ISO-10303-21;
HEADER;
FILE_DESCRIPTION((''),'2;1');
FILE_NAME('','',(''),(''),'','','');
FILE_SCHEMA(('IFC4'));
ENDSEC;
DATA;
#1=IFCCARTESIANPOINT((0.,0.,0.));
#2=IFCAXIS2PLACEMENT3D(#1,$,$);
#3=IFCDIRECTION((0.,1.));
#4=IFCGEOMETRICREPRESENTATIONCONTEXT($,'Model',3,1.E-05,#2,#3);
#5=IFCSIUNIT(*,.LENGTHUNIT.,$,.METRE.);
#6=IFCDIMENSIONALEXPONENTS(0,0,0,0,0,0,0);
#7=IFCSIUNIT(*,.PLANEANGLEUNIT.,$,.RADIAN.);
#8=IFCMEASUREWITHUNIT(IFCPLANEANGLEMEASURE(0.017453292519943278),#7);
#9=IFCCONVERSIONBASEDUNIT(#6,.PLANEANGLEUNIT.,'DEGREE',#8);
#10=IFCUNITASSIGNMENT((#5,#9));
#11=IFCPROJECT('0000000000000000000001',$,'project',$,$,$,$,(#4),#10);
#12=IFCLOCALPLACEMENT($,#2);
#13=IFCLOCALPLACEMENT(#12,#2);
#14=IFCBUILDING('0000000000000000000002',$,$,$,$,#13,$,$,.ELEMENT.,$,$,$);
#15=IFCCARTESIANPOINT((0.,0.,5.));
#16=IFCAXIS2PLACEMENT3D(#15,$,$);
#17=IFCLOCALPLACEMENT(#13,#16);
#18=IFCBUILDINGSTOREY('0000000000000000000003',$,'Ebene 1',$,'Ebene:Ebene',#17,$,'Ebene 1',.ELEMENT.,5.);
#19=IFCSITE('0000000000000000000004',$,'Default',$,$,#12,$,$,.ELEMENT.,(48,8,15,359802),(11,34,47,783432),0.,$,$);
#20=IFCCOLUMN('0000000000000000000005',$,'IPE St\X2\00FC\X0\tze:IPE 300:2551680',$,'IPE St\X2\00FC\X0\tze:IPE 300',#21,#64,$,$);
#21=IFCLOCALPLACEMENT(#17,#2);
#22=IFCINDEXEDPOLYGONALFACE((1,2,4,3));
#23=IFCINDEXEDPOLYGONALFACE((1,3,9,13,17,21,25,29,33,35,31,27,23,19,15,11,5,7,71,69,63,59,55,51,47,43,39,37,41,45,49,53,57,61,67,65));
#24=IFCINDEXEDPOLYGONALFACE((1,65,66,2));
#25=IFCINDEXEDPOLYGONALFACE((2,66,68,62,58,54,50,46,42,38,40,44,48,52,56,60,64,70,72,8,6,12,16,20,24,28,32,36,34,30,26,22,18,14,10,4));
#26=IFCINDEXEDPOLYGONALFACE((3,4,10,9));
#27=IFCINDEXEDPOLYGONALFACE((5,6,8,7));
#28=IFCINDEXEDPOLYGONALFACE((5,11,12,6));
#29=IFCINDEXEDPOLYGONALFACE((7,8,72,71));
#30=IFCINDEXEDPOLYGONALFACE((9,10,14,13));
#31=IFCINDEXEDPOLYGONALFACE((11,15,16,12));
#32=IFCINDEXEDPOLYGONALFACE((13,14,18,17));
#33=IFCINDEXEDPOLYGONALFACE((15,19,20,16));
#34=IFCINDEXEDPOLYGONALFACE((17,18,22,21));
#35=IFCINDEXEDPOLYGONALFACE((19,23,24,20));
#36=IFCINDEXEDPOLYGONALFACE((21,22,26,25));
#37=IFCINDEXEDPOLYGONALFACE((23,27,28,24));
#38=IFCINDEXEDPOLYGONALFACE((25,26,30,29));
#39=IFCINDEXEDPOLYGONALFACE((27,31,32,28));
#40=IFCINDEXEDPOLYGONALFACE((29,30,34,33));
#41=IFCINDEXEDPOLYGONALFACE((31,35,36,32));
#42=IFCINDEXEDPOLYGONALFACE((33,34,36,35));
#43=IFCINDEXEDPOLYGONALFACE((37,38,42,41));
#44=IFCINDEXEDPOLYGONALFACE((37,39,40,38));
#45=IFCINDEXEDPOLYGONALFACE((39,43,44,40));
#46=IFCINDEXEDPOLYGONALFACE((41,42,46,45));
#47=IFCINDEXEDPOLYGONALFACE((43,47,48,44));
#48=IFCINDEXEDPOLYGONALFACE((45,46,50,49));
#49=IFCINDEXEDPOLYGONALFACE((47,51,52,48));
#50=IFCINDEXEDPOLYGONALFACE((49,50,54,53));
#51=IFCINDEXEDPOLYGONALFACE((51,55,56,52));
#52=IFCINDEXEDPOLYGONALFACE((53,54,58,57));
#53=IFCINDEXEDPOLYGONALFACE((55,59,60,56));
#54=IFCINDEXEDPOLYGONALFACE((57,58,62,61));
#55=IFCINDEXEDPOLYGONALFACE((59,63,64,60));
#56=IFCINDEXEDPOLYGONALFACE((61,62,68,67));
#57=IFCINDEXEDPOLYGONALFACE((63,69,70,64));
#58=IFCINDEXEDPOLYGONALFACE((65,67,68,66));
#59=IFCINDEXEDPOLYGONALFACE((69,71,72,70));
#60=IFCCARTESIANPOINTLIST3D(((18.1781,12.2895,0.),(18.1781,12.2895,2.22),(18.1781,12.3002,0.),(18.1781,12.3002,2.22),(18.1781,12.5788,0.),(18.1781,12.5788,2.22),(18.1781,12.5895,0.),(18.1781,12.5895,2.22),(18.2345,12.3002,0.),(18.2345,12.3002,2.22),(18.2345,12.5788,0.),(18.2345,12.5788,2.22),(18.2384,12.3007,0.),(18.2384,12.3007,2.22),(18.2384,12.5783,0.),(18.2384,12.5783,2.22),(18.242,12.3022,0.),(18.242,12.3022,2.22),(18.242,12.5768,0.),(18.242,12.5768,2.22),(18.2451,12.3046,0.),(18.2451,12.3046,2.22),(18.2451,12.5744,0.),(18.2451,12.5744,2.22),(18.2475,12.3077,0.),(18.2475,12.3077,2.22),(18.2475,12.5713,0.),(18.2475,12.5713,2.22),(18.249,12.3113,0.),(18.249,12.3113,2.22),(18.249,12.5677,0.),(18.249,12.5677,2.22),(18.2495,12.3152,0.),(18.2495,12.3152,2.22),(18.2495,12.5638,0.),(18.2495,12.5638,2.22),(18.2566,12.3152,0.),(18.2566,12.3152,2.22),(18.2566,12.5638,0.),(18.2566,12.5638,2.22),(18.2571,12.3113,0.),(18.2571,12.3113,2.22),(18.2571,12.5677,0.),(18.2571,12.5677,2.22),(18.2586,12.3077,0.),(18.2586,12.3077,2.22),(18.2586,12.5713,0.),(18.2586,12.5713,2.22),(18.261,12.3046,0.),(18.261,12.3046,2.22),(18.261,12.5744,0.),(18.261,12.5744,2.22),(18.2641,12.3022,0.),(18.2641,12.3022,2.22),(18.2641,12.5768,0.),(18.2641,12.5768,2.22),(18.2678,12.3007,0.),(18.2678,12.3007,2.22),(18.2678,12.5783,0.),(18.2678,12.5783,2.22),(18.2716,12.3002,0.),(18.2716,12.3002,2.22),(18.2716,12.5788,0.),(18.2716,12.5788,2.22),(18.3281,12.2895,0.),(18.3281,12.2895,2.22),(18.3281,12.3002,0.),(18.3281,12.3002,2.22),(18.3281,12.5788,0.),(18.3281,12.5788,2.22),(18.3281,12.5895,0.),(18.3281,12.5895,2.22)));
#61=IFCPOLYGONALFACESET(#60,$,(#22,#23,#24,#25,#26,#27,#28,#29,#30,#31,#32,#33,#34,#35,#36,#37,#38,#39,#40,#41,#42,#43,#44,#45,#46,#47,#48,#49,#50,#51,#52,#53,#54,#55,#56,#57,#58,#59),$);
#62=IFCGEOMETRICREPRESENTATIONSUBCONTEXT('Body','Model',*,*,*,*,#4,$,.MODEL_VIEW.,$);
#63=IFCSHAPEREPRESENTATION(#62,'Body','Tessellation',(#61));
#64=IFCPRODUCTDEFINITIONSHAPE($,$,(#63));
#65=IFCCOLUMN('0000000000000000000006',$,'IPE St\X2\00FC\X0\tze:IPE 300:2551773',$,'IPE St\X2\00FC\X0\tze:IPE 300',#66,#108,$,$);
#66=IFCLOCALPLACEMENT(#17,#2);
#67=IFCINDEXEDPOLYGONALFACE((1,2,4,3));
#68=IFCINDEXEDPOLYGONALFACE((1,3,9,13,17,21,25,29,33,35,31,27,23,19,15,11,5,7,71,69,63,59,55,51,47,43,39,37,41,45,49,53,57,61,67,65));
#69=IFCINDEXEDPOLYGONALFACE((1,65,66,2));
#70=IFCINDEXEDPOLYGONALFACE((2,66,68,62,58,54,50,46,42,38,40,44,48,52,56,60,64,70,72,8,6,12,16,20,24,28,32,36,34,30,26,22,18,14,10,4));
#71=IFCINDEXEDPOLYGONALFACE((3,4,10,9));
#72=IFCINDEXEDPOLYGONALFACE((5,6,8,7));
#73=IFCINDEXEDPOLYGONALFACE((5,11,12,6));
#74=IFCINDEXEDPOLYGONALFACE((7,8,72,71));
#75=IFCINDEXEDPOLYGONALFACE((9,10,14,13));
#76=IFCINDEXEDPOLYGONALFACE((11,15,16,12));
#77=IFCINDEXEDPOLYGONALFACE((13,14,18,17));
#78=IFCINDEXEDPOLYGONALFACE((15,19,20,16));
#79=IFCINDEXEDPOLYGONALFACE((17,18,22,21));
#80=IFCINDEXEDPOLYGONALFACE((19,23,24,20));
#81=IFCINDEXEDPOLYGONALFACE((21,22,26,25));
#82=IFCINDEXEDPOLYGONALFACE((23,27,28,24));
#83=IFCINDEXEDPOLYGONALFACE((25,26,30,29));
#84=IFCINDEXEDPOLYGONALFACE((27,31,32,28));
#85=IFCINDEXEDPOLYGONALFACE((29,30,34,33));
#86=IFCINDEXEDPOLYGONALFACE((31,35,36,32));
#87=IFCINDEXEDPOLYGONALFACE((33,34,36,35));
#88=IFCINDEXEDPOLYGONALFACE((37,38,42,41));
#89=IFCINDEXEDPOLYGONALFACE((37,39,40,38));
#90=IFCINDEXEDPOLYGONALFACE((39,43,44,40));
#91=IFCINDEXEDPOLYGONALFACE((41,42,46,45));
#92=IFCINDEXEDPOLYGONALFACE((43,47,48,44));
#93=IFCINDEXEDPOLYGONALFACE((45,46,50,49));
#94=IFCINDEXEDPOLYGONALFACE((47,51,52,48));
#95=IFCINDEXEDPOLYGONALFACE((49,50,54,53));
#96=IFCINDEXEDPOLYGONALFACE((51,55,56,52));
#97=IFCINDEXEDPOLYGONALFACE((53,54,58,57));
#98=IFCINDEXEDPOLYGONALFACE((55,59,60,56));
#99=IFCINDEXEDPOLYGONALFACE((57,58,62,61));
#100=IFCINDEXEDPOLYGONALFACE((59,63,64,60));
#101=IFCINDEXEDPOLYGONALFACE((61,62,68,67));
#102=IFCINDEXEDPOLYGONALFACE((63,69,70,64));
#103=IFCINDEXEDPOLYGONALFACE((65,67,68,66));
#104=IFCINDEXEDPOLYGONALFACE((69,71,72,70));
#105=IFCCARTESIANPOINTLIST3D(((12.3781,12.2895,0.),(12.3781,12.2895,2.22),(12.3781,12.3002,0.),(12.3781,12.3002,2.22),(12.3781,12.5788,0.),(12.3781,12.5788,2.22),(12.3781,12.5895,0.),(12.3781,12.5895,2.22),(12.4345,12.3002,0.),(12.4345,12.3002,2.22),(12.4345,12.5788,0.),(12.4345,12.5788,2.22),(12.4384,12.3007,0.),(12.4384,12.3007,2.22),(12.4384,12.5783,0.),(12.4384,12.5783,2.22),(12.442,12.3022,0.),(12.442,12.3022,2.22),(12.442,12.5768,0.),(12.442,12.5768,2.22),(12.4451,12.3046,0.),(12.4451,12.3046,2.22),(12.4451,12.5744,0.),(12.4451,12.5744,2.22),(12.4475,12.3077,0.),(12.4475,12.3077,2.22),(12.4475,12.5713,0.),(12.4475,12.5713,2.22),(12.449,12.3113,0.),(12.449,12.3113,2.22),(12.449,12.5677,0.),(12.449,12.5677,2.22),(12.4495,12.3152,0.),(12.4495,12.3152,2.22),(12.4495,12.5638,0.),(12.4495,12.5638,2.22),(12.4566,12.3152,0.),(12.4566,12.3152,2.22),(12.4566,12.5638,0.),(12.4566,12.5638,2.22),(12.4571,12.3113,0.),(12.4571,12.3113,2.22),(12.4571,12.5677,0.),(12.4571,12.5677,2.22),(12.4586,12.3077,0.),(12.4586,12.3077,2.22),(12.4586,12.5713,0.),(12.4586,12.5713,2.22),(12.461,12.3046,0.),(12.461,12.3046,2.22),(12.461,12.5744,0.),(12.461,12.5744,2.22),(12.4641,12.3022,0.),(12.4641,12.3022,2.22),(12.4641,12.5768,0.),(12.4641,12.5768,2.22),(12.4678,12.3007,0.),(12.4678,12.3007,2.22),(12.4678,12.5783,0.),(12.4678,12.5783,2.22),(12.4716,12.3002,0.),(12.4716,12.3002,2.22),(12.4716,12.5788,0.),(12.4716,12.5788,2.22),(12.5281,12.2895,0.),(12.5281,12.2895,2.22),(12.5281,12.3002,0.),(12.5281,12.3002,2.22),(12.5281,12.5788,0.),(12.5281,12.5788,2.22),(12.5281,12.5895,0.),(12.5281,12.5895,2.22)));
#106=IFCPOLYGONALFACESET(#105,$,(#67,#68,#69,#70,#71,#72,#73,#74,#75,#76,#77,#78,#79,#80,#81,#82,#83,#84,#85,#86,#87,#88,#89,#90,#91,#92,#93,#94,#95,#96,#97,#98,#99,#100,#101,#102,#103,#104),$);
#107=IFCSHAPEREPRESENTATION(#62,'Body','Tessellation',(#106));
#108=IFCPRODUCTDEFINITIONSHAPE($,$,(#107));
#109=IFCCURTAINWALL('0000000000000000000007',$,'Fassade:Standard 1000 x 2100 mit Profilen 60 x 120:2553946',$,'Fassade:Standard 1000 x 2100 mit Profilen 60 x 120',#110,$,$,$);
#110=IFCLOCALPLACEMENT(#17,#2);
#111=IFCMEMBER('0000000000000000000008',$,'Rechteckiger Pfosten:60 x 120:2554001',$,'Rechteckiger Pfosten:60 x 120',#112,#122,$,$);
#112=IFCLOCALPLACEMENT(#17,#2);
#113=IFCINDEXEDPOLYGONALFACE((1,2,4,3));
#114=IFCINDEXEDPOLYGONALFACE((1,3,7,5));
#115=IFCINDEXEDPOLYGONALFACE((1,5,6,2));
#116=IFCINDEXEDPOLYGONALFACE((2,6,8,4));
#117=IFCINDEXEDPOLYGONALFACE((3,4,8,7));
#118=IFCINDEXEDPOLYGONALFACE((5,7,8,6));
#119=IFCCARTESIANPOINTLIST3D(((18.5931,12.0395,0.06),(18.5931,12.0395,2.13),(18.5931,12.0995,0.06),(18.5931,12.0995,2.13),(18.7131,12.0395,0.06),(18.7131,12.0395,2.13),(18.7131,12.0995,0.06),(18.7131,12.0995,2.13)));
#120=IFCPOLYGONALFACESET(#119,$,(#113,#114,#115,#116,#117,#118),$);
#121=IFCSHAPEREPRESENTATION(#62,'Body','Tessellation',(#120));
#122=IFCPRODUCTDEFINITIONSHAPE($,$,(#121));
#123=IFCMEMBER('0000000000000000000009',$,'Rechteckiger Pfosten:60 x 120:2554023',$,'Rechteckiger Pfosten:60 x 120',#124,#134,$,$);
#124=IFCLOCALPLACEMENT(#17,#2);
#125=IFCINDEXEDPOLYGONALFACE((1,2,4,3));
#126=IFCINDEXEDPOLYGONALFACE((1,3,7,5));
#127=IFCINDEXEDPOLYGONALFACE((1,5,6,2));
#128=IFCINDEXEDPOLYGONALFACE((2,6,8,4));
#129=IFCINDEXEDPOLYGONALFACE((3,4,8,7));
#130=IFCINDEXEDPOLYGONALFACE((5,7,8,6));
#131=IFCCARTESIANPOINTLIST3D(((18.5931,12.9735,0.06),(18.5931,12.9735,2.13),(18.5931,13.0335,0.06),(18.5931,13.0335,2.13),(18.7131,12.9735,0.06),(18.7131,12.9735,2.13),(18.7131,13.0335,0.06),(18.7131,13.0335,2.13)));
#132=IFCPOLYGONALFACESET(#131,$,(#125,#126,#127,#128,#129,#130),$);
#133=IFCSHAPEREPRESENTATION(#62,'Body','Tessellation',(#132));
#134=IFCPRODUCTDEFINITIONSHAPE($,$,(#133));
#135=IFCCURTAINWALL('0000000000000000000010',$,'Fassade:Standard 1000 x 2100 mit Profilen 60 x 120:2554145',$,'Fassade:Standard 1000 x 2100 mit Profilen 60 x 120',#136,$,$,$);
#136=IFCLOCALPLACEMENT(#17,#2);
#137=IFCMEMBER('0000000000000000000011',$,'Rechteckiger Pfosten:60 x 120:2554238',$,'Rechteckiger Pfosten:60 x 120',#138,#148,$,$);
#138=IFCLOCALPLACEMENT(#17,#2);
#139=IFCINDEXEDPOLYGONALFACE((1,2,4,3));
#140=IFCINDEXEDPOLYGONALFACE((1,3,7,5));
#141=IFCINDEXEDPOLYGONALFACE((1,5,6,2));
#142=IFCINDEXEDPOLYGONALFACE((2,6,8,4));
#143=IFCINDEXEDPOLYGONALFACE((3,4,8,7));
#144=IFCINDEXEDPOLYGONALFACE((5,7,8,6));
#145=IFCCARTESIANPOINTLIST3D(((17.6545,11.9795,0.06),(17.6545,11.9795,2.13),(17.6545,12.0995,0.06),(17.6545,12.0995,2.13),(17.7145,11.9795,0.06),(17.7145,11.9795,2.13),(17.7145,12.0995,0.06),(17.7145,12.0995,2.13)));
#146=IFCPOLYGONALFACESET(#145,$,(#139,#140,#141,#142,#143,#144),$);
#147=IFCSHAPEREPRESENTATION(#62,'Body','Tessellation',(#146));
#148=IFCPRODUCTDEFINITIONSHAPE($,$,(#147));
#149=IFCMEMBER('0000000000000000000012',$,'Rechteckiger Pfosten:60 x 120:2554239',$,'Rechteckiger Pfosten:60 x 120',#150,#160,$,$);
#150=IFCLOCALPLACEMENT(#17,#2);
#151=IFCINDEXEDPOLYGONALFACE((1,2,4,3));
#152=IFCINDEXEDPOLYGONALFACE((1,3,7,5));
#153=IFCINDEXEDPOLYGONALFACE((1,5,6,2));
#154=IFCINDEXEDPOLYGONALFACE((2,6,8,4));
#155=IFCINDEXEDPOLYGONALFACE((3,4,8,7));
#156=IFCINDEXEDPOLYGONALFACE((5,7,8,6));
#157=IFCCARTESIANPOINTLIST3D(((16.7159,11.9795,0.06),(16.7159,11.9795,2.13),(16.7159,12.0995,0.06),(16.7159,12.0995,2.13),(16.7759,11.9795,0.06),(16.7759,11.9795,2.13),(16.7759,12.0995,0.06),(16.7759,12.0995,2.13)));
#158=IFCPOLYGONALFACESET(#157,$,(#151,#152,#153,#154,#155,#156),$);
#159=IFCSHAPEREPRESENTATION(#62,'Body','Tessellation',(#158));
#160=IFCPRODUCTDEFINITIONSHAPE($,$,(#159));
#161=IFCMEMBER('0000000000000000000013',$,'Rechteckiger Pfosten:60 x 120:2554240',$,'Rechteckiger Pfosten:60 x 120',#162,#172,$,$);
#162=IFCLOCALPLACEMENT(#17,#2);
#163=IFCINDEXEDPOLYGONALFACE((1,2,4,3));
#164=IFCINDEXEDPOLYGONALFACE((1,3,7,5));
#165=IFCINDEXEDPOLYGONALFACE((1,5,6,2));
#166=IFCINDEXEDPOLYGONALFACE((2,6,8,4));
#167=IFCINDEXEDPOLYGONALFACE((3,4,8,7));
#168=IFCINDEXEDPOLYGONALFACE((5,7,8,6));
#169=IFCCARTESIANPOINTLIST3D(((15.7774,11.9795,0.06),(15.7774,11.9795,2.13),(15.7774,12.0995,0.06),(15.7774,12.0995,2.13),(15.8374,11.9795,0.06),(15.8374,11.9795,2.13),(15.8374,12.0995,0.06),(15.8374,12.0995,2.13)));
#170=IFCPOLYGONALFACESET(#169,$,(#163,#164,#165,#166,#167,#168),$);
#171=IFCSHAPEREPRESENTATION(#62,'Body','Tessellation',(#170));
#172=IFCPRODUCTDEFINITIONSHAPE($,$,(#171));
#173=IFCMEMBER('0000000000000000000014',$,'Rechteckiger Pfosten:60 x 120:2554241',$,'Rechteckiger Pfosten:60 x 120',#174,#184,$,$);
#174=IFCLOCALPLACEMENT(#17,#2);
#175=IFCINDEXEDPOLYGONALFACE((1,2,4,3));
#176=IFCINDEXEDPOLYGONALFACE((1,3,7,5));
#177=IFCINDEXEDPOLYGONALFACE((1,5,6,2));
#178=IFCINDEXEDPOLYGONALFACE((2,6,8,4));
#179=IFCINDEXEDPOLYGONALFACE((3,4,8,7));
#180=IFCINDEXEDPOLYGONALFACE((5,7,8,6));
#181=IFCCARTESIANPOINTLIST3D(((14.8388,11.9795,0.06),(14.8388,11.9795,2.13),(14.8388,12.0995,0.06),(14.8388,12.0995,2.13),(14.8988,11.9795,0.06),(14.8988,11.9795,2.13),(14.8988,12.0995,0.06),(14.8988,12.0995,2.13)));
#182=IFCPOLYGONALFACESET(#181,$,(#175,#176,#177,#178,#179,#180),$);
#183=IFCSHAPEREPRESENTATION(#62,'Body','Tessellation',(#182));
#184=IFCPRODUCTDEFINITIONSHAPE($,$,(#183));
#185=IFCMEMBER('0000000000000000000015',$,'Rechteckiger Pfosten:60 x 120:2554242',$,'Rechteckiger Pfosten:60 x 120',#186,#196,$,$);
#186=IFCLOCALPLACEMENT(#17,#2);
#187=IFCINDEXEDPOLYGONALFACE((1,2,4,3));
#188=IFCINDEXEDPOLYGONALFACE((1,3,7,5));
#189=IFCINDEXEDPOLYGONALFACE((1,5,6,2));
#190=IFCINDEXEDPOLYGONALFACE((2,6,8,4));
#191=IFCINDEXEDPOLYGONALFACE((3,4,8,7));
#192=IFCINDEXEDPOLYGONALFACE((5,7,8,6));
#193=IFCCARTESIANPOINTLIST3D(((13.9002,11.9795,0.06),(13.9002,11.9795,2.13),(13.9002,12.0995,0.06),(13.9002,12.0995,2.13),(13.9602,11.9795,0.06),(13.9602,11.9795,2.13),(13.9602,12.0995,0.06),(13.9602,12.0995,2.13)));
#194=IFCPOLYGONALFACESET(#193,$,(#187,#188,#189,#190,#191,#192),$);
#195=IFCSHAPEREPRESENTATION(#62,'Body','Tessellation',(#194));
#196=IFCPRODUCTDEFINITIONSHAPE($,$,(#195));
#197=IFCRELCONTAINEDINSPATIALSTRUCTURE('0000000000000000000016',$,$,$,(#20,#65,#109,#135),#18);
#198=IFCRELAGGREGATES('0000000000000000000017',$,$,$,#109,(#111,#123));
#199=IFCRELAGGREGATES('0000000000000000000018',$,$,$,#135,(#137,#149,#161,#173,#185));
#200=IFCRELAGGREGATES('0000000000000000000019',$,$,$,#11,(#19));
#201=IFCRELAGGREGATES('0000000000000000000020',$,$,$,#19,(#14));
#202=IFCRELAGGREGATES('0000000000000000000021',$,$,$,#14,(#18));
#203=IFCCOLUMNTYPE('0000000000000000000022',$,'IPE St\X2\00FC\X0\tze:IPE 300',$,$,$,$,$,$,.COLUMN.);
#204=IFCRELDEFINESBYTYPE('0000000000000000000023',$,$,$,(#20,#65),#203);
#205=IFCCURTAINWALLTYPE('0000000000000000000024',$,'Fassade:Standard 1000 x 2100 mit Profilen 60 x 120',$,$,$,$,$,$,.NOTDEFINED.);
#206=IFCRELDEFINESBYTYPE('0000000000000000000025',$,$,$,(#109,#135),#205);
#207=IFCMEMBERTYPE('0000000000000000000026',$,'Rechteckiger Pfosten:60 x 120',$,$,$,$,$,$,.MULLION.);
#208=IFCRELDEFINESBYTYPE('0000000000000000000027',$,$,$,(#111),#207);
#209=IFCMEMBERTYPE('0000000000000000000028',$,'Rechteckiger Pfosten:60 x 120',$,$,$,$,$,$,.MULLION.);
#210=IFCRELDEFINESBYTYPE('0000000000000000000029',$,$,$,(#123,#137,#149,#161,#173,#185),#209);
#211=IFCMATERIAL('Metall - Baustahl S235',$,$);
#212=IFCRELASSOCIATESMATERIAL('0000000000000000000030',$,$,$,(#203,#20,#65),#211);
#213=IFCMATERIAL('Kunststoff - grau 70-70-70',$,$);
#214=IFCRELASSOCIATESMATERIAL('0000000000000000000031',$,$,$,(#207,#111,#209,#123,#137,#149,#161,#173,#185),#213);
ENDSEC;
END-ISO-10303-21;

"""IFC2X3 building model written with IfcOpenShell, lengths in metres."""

from ifc_helpers import new_model, entity, si_unit, converted_unit, direction, frame, origin, origin_2d_with_axis, place, context, subcontext, project, spatial, rectangle, i_section, extrude, source, transform, mapped, material, type_object, type_shapes, element, aggregate, save


model = new_model("IFC2X3")

# Units and contexts
model_context = context("Model", 3, precision=1e-05, world=origin(), true_north=direction((0.0, 1.0)))
body_context = subcontext(model_context, "Body", "Model", "MODEL_VIEW")
ifc_project = project(units=[si_unit("LENGTHUNIT", "METRE"), converted_unit("PLANEANGLEUNIT", "DEGREE", entity("IfcPlaneAngleMeasure", 0.017453292519943278), si_unit("PLANEANGLEUNIT", "RADIAN"), dimensions=[0, 0, 0, 0, 0, 0, 0])], contexts=[model_context])

# Site, building, storey
site_placement = place(None, origin())
site = spatial("IfcSite", under=ifc_project, at=site_placement, Name="Default", CompositionType="ELEMENT", RefLatitude=(48, 8, 15, 359802), RefLongitude=(11, 34, 47, 783432), RefElevation=0.0)
building_placement = place(site_placement, origin())
building = spatial("IfcBuilding", under=site, at=building_placement, CompositionType="ELEMENT")
storey_placement = place(building_placement, frame((0.0, 0.0, 5.0)))
storey = spatial("IfcBuildingStorey", under=building, at=storey_placement, Name="Ebene 1", ObjectType="Ebene:Ebene", LongName="Ebene 1", CompositionType="ELEMENT", Elevation=5.0)

# Columns
ifc_material_1 = material(Name="Metall - Baustahl S235")
column_type = type_object("IfcColumnType", Name="IPE Stütze:IPE 300", PredefinedType="COLUMN", material=ifc_material_1)
shared_shape_1 = source(origin(), body_context, "Body", "SweptSolid", [
    extrude(i_section(OverallWidth=0.15, OverallDepth=0.3, WebThickness=0.0071, FlangeThickness=0.0107, FilletRadius=0.015, at=origin_2d_with_axis()), frame((0.0, 0.0, 5.0), z_axis=(0.0, 0.0, 1.0), x_axis=(-1.0, 0.0, 0.0)), (0.0, 0.0, 1.0), 2.22),
])
type_shapes(column_type, [shared_shape_1])
for number, where, name in (
    (1, (18.2531, 12.4395, -5.0), "IPE Stütze:IPE 300:2551680"),
    (2, (12.4531, 12.4395, -5.0), "IPE Stütze:IPE 300:2551773"),
):
    element("IfcColumn", number, at=place(storey_placement, frame(where)), inside=storey, type_object=column_type, material=ifc_material_1, Name=name, ObjectType="IPE Stütze:IPE 300", context=body_context, shape_type="MappedRepresentation", body=[
        mapped(shared_shape_1, transform((0.0, 0.0, 0.0), scale=1.0)),
    ])

# Curtain walls, members
curtain_wall_type = type_object("IfcCurtainWallType", Name="Fassade:Standard 1000 x 2100 mit Profilen 60 x 120", PredefinedType="NOTDEFINED")
curtain_wall_1_placement = place(storey_placement, frame((0.0, 0.0, -5.0)))
curtain_wall_1 = element("IfcCurtainWall", 3, at=curtain_wall_1_placement, inside=storey, type_object=curtain_wall_type, Name="Fassade:Standard 1000 x 2100 mit Profilen 60 x 120:2553946", ObjectType="Fassade:Standard 1000 x 2100 mit Profilen 60 x 120")
ifc_material_2 = material(Name="Kunststoff - grau 70-70-70")
member_type_1 = type_object("IfcMemberType", Name="Rechteckiger Pfosten:60 x 120", PredefinedType="MULLION", material=ifc_material_2)
shared_shape_2 = source(origin(), body_context, "Body", "SweptSolid", [
    extrude(rectangle(XDim=0.06, YDim=0.12, at=origin_2d_with_axis()), frame((-0.03, 0.0, -2.07), z_axis=(0.0, 0.0, 1.0), x_axis=(-1.0, 0.0, 0.0)), (0.0, 0.0, 1.0), 2.07),
])
type_shapes(member_type_1, [shared_shape_2])
member_1_placement = place(curtain_wall_1_placement, frame((18.6531, 12.0395, 5.06), z_axis=(0.0, 0.0, -1.0), x_axis=(0.0, -1.0, 0.0)))
member_1 = element("IfcMember", 4, at=member_1_placement, type_object=member_type_1, material=ifc_material_2, Name="Rechteckiger Pfosten:60 x 120:2554001", ObjectType="Rechteckiger Pfosten:60 x 120", context=body_context, shape_type="MappedRepresentation", body=[
    mapped(shared_shape_2, transform((0.0, 0.0, 0.0), scale=1.0)),
])
member_type_2 = type_object("IfcMemberType", Name="Rechteckiger Pfosten:60 x 120", PredefinedType="MULLION", material=ifc_material_2)
shared_shape_3 = source(origin(), body_context, "Body", "SweptSolid", [
    extrude(rectangle(XDim=0.06, YDim=0.12, at=origin_2d_with_axis()), frame((0.0, 0.0, -2.07), z_axis=(0.0, 0.0, 1.0), x_axis=(-1.0, 0.0, 0.0)), (0.0, 0.0, 1.0), 2.07),
])
type_shapes(member_type_2, [shared_shape_3])
member_2_placement = place(curtain_wall_1_placement, frame((18.6531, 13.0035, 5.06), z_axis=(0.0, 0.0, -1.0), x_axis=(0.0, -1.0, 0.0)))
member_2 = element("IfcMember", 5, at=member_2_placement, type_object=member_type_2, material=ifc_material_2, Name="Rechteckiger Pfosten:60 x 120:2554023", ObjectType="Rechteckiger Pfosten:60 x 120", context=body_context, shape_type="MappedRepresentation", body=[
    mapped(shared_shape_3, transform((0.0, 0.0, 0.0), scale=1.0)),
])
curtain_wall_2_placement = place(storey_placement, frame((0.0, 0.0, -5.0)))
curtain_wall_2 = element("IfcCurtainWall", 6, at=curtain_wall_2_placement, inside=storey, type_object=curtain_wall_type, Name="Fassade:Standard 1000 x 2100 mit Profilen 60 x 120:2554145", ObjectType="Fassade:Standard 1000 x 2100 mit Profilen 60 x 120")
member_3_placement = place(curtain_wall_2_placement, frame((17.6845, 12.0395, 5.06), z_axis=(0.0, 0.0, -1.0), x_axis=(-1.0, 0.0, 0.0)))
member_3 = element("IfcMember", 7, at=member_3_placement, type_object=member_type_2, material=ifc_material_2, Name="Rechteckiger Pfosten:60 x 120:2554238", ObjectType="Rechteckiger Pfosten:60 x 120", context=body_context, shape_type="MappedRepresentation", body=[
    mapped(shared_shape_3, transform((0.0, 0.0, 0.0), scale=1.0)),
])
member_4_placement = place(curtain_wall_2_placement, frame((16.7459, 12.0395, 5.06), z_axis=(0.0, 0.0, -1.0), x_axis=(-1.0, 0.0, 0.0)))
member_4 = element("IfcMember", 8, at=member_4_placement, type_object=member_type_2, material=ifc_material_2, Name="Rechteckiger Pfosten:60 x 120:2554239", ObjectType="Rechteckiger Pfosten:60 x 120", context=body_context, shape_type="MappedRepresentation", body=[
    mapped(shared_shape_3, transform((0.0, 0.0, 0.0), scale=1.0)),
])
member_5_placement = place(curtain_wall_2_placement, frame((15.8074, 12.0395, 5.06), z_axis=(0.0, 0.0, -1.0), x_axis=(-1.0, 0.0, 0.0)))
member_5 = element("IfcMember", 9, at=member_5_placement, type_object=member_type_2, material=ifc_material_2, Name="Rechteckiger Pfosten:60 x 120:2554240", ObjectType="Rechteckiger Pfosten:60 x 120", context=body_context, shape_type="MappedRepresentation", body=[
    mapped(shared_shape_3, transform((0.0, 0.0, 0.0), scale=1.0)),
])
member_6_placement = place(curtain_wall_2_placement, frame((14.8688, 12.0395, 5.06), z_axis=(0.0, 0.0, -1.0), x_axis=(-1.0, 0.0, 0.0)))
member_6 = element("IfcMember", 10, at=member_6_placement, type_object=member_type_2, material=ifc_material_2, Name="Rechteckiger Pfosten:60 x 120:2554241", ObjectType="Rechteckiger Pfosten:60 x 120", context=body_context, shape_type="MappedRepresentation", body=[
    mapped(shared_shape_3, transform((0.0, 0.0, 0.0), scale=1.0)),
])
member_7_placement = place(curtain_wall_2_placement, frame((13.9302, 12.0395, 5.06), z_axis=(0.0, 0.0, -1.0), x_axis=(-1.0, 0.0, 0.0)))
member_7 = element("IfcMember", 11, at=member_7_placement, type_object=member_type_2, material=ifc_material_2, Name="Rechteckiger Pfosten:60 x 120:2554242", ObjectType="Rechteckiger Pfosten:60 x 120", context=body_context, shape_type="MappedRepresentation", body=[
    mapped(shared_shape_3, transform((0.0, 0.0, 0.0), scale=1.0)),
])

aggregate(curtain_wall_1, [member_1, member_2])
aggregate(curtain_wall_2, [member_3, member_4, member_5, member_6, member_7])

save(model, "model.ifc")
